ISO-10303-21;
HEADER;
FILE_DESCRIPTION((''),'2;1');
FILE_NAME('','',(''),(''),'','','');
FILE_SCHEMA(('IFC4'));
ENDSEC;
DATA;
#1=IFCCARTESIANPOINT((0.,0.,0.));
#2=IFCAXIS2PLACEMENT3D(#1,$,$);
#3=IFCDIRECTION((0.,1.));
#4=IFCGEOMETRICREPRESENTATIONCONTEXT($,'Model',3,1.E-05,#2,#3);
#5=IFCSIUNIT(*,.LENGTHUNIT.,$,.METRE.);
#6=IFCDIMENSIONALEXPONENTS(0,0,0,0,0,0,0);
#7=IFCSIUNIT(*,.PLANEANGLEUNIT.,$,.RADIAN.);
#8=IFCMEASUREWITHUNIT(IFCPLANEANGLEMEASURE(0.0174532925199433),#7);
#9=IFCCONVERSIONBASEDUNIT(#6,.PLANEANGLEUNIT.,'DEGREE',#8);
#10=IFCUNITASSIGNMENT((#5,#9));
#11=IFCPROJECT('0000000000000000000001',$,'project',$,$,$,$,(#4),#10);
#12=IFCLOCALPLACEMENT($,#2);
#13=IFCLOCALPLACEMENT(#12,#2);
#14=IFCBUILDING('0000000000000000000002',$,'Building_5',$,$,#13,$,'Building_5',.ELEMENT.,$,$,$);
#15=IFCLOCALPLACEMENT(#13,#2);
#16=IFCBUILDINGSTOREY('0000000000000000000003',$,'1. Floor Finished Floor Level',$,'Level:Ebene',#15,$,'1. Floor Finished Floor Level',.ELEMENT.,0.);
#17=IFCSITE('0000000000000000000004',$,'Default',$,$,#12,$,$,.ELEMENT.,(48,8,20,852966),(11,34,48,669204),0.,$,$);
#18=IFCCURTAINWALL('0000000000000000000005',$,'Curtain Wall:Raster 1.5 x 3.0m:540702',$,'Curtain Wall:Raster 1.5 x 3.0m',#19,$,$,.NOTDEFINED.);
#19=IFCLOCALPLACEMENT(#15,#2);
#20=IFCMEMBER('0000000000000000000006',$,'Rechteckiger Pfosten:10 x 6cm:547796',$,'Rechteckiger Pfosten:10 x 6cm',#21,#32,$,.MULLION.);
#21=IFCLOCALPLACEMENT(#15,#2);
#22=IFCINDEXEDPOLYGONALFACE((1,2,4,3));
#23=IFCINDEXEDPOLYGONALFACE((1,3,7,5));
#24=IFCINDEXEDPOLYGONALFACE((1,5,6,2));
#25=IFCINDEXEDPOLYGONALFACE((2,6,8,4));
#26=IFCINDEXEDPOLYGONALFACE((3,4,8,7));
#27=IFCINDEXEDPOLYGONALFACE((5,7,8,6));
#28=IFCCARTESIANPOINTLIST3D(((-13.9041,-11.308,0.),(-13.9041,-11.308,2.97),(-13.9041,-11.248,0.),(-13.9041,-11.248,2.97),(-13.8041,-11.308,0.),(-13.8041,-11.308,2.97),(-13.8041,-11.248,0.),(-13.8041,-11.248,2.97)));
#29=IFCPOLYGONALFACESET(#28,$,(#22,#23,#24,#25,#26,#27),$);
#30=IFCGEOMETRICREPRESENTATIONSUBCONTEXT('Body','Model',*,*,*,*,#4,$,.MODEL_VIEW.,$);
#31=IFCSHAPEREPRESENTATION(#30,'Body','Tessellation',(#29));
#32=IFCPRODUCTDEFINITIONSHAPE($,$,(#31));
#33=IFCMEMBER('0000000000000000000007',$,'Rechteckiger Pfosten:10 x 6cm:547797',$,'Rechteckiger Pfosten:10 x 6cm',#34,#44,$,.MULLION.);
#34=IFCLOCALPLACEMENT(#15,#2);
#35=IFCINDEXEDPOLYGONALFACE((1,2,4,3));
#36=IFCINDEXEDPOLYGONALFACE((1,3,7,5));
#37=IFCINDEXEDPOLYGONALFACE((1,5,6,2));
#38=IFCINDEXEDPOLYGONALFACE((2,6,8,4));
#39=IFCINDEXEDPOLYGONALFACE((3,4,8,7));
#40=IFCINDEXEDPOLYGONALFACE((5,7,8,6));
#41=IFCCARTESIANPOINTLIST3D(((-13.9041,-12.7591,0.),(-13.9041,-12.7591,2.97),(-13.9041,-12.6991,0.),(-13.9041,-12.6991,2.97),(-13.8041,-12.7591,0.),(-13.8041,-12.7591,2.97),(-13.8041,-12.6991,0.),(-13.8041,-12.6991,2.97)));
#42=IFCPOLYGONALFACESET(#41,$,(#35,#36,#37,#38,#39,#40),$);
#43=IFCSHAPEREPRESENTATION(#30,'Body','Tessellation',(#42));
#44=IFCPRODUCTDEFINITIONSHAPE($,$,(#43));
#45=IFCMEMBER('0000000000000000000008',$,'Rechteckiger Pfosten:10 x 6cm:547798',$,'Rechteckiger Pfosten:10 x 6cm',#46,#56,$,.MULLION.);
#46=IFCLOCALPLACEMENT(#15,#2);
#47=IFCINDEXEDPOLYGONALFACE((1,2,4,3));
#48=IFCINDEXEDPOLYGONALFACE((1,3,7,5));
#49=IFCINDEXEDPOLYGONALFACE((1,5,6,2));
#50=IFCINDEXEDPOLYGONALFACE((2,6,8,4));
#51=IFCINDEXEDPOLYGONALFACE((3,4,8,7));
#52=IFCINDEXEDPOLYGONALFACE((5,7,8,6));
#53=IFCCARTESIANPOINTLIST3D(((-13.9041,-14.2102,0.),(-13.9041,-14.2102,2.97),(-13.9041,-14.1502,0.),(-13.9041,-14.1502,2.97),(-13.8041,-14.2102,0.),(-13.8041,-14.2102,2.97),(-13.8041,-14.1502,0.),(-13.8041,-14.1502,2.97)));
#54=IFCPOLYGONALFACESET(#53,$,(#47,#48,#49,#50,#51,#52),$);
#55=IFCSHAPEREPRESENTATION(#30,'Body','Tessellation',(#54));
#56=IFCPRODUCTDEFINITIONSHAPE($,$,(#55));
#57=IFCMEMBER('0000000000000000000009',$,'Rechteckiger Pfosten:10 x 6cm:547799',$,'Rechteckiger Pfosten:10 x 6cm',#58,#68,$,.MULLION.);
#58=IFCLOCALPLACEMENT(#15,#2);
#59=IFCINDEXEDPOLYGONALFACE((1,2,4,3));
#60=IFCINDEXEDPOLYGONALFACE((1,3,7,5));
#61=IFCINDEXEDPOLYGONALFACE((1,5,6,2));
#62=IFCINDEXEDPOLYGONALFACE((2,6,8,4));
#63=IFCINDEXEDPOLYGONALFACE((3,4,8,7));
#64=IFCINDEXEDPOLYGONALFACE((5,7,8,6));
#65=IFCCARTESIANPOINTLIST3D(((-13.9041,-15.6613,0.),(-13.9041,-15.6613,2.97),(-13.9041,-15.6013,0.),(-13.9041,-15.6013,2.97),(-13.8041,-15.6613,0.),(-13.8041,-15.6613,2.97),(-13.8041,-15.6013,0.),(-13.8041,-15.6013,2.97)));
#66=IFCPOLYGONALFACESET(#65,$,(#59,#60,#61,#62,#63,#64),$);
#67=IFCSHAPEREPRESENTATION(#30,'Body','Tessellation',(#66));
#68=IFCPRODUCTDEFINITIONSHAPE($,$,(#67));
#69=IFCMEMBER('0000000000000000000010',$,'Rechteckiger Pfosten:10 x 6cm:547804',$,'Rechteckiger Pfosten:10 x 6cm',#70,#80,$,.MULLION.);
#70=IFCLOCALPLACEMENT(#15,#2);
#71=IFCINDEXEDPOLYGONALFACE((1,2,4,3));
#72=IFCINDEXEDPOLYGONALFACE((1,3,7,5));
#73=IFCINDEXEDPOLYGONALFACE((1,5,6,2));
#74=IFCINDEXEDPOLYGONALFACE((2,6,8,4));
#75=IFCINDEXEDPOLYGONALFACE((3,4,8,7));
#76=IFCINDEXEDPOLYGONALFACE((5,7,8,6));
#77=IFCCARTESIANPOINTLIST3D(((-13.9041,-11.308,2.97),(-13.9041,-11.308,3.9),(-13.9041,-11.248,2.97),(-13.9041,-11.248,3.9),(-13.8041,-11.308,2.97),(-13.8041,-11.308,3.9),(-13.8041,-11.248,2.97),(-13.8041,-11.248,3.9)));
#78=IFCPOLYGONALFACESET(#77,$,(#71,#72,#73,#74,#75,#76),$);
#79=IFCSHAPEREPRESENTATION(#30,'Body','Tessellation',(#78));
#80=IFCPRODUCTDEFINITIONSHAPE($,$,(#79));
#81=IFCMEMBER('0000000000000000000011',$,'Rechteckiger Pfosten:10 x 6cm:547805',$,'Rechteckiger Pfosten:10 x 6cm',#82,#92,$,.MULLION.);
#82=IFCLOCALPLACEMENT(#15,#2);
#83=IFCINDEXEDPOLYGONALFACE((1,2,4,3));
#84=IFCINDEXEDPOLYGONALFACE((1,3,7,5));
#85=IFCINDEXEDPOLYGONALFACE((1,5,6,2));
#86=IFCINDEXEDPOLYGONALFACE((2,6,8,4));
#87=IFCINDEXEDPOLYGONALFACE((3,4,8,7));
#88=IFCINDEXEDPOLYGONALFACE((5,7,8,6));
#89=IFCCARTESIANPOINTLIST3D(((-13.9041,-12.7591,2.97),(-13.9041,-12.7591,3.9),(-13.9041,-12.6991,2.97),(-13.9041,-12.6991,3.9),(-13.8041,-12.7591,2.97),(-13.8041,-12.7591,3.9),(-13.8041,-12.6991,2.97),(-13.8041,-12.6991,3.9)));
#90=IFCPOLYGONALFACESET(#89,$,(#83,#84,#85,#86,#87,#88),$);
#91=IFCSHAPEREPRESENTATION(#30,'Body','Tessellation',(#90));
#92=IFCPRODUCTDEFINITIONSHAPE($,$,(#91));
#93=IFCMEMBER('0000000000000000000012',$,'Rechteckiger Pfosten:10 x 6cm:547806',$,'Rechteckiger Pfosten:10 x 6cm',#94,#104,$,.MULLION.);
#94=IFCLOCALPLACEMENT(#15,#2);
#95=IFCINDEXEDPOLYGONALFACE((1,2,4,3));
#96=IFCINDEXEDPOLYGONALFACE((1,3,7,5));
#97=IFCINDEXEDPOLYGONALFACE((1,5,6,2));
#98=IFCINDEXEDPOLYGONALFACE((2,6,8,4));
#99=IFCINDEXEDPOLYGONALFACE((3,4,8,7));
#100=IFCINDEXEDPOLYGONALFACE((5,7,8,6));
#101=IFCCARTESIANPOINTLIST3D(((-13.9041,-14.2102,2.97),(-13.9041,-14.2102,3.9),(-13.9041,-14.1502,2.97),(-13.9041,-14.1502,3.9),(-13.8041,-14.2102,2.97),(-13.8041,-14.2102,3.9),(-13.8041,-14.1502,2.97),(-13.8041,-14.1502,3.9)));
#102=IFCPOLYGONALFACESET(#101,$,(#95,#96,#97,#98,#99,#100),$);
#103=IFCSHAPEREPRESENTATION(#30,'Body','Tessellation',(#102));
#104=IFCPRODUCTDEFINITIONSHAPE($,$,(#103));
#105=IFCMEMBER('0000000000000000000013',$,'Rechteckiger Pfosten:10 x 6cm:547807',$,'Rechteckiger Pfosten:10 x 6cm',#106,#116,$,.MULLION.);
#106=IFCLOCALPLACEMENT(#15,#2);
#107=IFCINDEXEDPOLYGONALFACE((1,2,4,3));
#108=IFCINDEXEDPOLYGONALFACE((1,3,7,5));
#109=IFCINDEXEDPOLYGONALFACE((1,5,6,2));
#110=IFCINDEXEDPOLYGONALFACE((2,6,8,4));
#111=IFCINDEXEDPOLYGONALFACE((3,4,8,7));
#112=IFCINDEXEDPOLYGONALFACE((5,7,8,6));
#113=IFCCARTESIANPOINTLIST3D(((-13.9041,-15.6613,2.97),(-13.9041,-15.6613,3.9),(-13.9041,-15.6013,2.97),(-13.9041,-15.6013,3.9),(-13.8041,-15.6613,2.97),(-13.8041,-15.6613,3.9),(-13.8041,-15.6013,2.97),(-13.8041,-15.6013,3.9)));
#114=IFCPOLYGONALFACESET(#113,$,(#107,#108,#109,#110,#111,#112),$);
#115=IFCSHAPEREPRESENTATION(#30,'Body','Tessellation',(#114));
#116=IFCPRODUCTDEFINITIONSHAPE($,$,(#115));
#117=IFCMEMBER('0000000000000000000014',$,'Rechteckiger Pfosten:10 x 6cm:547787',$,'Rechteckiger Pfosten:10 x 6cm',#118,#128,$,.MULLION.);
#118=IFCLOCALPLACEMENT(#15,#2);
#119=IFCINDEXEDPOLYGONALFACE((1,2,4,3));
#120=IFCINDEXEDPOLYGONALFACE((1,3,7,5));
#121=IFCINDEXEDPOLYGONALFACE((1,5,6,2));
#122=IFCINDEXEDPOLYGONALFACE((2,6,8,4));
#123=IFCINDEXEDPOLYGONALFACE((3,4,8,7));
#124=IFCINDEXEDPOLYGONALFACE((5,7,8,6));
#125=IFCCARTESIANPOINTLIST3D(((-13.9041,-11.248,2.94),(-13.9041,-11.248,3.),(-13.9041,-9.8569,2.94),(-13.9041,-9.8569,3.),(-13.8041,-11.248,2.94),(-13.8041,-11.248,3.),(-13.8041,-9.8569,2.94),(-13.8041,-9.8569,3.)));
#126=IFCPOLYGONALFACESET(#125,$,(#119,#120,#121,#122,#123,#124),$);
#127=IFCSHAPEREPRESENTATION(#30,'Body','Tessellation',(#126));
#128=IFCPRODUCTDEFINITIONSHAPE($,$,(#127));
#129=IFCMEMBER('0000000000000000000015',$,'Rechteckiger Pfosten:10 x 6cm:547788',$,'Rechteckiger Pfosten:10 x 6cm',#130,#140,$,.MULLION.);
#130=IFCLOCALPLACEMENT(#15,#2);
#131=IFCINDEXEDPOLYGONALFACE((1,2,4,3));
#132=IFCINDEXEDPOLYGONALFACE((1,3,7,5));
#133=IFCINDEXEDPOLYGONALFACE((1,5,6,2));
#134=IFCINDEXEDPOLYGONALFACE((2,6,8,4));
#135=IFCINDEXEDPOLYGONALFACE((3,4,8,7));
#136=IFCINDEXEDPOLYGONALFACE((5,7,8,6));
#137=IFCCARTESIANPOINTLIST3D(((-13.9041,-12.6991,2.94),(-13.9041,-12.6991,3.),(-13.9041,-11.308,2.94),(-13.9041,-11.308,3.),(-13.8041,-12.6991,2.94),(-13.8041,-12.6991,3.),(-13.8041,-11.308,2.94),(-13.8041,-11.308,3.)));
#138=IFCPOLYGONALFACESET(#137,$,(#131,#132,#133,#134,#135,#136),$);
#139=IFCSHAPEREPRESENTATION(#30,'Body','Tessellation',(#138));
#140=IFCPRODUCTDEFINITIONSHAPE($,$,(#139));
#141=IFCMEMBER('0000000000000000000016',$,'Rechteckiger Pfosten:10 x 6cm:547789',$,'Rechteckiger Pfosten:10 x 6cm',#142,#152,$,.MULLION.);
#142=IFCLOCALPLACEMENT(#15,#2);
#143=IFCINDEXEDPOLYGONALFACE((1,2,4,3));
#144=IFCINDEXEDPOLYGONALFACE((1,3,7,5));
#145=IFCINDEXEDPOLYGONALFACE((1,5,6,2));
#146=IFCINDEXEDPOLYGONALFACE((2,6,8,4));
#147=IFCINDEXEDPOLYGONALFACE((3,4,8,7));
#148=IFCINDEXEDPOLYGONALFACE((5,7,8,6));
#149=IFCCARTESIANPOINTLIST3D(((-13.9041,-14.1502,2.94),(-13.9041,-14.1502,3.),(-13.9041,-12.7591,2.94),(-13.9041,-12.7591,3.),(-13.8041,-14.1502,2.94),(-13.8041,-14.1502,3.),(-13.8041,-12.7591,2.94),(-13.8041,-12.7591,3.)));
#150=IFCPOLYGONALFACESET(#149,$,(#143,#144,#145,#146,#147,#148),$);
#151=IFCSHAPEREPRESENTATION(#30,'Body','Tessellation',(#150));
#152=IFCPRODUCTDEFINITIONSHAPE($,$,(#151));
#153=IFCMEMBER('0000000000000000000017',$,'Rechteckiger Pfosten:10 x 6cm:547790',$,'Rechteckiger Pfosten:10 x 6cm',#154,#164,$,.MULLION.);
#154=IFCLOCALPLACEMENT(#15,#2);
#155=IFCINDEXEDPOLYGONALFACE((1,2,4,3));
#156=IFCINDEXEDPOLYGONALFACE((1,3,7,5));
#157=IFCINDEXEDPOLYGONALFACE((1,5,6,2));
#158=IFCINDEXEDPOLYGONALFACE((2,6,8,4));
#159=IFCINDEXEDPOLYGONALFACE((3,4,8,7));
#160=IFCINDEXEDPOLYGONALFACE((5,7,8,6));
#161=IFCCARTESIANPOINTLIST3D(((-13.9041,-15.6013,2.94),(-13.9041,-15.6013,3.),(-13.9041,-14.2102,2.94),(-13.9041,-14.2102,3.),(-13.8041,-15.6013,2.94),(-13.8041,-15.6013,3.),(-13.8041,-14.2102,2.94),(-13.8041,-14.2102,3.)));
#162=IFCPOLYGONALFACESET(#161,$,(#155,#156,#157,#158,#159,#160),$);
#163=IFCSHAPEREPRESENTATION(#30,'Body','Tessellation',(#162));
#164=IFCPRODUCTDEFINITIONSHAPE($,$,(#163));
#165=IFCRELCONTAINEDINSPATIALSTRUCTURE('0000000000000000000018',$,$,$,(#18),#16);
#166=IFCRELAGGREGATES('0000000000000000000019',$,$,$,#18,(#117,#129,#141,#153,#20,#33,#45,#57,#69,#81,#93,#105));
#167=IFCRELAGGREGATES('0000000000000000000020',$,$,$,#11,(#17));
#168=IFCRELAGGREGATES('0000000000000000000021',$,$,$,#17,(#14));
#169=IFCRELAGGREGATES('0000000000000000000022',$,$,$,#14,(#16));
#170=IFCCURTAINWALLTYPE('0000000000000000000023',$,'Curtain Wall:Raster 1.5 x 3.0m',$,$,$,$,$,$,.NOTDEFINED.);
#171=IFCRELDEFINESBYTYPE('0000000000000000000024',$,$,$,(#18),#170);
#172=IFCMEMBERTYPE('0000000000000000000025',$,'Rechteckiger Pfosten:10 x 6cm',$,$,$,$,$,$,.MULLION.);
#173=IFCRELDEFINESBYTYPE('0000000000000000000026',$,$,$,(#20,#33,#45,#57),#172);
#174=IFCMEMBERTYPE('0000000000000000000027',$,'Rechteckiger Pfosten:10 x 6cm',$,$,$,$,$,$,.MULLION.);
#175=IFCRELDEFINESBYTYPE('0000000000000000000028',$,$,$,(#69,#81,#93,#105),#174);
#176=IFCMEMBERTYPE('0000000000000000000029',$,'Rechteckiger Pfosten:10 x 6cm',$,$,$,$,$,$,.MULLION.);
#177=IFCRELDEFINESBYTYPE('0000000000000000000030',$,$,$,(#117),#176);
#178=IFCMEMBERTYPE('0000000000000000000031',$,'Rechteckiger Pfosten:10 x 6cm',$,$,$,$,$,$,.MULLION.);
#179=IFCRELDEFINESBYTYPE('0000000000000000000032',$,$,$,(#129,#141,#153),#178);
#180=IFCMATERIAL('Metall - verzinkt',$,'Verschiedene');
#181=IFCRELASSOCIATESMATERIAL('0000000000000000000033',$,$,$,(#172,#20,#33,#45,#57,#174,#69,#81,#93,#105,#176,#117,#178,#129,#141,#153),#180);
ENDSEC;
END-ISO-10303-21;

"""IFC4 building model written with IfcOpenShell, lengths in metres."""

from ifc_helpers import new_model, entity, si_unit, converted_unit, direction, frame, origin, place, context, subcontext, project, spatial, indexed_curve, outline, extrude, source, transform, mapped, material, type_object, type_shapes, element, aggregate, save


model = new_model("IFC4")

# Units and contexts
model_context = context("Model", 3, precision=1e-05, world=origin(), true_north=direction((0.0, 1.0)))
body_context = subcontext(model_context, "Body", "Model", "MODEL_VIEW")
ifc_project = project(units=[si_unit("LENGTHUNIT", "METRE"), converted_unit("PLANEANGLEUNIT", "DEGREE", entity("IfcPlaneAngleMeasure", 0.0174532925199433), si_unit("PLANEANGLEUNIT", "RADIAN"), dimensions=[0, 0, 0, 0, 0, 0, 0])], contexts=[model_context])

# Site, building, storey
site_placement = place(None, origin())
site = spatial("IfcSite", under=ifc_project, at=site_placement, Name="Default", CompositionType="ELEMENT", RefLatitude=(48, 8, 20, 852966), RefLongitude=(11, 34, 48, 669204), RefElevation=0.0)
building_placement = place(site_placement, origin())
building = spatial("IfcBuilding", under=site, at=building_placement, Name="Building_5", LongName="Building_5", CompositionType="ELEMENT")
storey_placement = place(building_placement, origin())
storey = spatial("IfcBuildingStorey", under=building, at=storey_placement, Name="1. Floor Finished Floor Level", ObjectType="Level:Ebene", LongName="1. Floor Finished Floor Level", CompositionType="ELEMENT", Elevation=0.0)

# Curtain wall, members
curtain_wall_type = type_object("IfcCurtainWallType", Name="Curtain Wall:Raster 1.5 x 3.0m", PredefinedType="NOTDEFINED")
curtain_wall_placement = place(storey_placement, origin())
curtain_wall = element("IfcCurtainWall", 1, at=curtain_wall_placement, inside=storey, type_object=curtain_wall_type, Name="Curtain Wall:Raster 1.5 x 3.0m:540702", ObjectType="Curtain Wall:Raster 1.5 x 3.0m", PredefinedType="NOTDEFINED")
ifc_material_1 = material(Name="Metall - verzinkt", Category="Verschiedene")
member_type_1 = type_object("IfcMemberType", Name="Rechteckiger Pfosten:10 x 6cm", PredefinedType="MULLION", material=ifc_material_1)
shared_shape_1 = source(origin(), body_context, "Body", "SweptSolid", [
    extrude(outline(indexed_curve([(-0.03, -0.05), (0.03, -0.05), (0.03, 0.05), (-0.03, 0.05), (-0.03, -0.05)], self_intersect=False)), frame((0.0, 0.0, -2.97), z_axis=(0.0, 0.0, 1.0), x_axis=(-1.0, 0.0, 0.0)), (0.0, 0.0, 1.0), 2.97),
])
type_shapes(member_type_1, [shared_shape_1])
member_1_placement = place(curtain_wall_placement, frame((-13.8541, -11.278, 0.0), z_axis=(0.0, 0.0, -1.0), x_axis=(0.0, -1.0, 0.0)))
member_1 = element("IfcMember", 2, at=member_1_placement, type_object=member_type_1, material=ifc_material_1, Name="Rechteckiger Pfosten:10 x 6cm:547796", ObjectType="Rechteckiger Pfosten:10 x 6cm", PredefinedType="MULLION", context=body_context, shape_type="MappedRepresentation", body=[
    mapped(shared_shape_1, transform((0.0, 0.0, 0.0), scale=1.0)),
])
member_2_placement = place(curtain_wall_placement, frame((-13.8541, -12.7291, 0.0), z_axis=(0.0, 0.0, -1.0), x_axis=(0.0, -1.0, 0.0)))
member_2 = element("IfcMember", 3, at=member_2_placement, type_object=member_type_1, material=ifc_material_1, Name="Rechteckiger Pfosten:10 x 6cm:547797", ObjectType="Rechteckiger Pfosten:10 x 6cm", PredefinedType="MULLION", context=body_context, shape_type="MappedRepresentation", body=[
    mapped(shared_shape_1, transform((0.0, 0.0, 0.0), scale=1.0)),
])
member_3_placement = place(curtain_wall_placement, frame((-13.8541, -14.1802, 0.0), z_axis=(0.0, 0.0, -1.0), x_axis=(0.0, -1.0, 0.0)))
member_3 = element("IfcMember", 4, at=member_3_placement, type_object=member_type_1, material=ifc_material_1, Name="Rechteckiger Pfosten:10 x 6cm:547798", ObjectType="Rechteckiger Pfosten:10 x 6cm", PredefinedType="MULLION", context=body_context, shape_type="MappedRepresentation", body=[
    mapped(shared_shape_1, transform((0.0, 0.0, 0.0), scale=1.0)),
])
member_4_placement = place(curtain_wall_placement, frame((-13.8541, -15.6313, 0.0), z_axis=(0.0, 0.0, -1.0), x_axis=(0.0, -1.0, 0.0)))
member_4 = element("IfcMember", 5, at=member_4_placement, type_object=member_type_1, material=ifc_material_1, Name="Rechteckiger Pfosten:10 x 6cm:547799", ObjectType="Rechteckiger Pfosten:10 x 6cm", PredefinedType="MULLION", context=body_context, shape_type="MappedRepresentation", body=[
    mapped(shared_shape_1, transform((0.0, 0.0, 0.0), scale=1.0)),
])
member_type_2 = type_object("IfcMemberType", Name="Rechteckiger Pfosten:10 x 6cm", PredefinedType="MULLION", material=ifc_material_1)
shared_shape_2 = source(origin(), body_context, "Body", "SweptSolid", [
    extrude(outline(indexed_curve([(-0.03, -0.05), (0.03, -0.05), (0.03, 0.05), (-0.03, 0.05), (-0.03, -0.05)], self_intersect=False)), frame((0.0, 0.0, -0.93), z_axis=(0.0, 0.0, 1.0), x_axis=(-1.0, 0.0, 0.0)), (0.0, 0.0, 1.0), 0.93),
])
type_shapes(member_type_2, [shared_shape_2])
member_5_placement = place(curtain_wall_placement, frame((-13.8541, -11.278, 2.97), z_axis=(0.0, 0.0, -1.0), x_axis=(0.0, -1.0, 0.0)))
member_5 = element("IfcMember", 6, at=member_5_placement, type_object=member_type_2, material=ifc_material_1, Name="Rechteckiger Pfosten:10 x 6cm:547804", ObjectType="Rechteckiger Pfosten:10 x 6cm", PredefinedType="MULLION", context=body_context, shape_type="MappedRepresentation", body=[
    mapped(shared_shape_2, transform((0.0, 0.0, 0.0), scale=1.0)),
])
member_6_placement = place(curtain_wall_placement, frame((-13.8541, -12.7291, 2.97), z_axis=(0.0, 0.0, -1.0), x_axis=(0.0, -1.0, 0.0)))
member_6 = element("IfcMember", 7, at=member_6_placement, type_object=member_type_2, material=ifc_material_1, Name="Rechteckiger Pfosten:10 x 6cm:547805", ObjectType="Rechteckiger Pfosten:10 x 6cm", PredefinedType="MULLION", context=body_context, shape_type="MappedRepresentation", body=[
    mapped(shared_shape_2, transform((0.0, 0.0, 0.0), scale=1.0)),
])
member_7_placement = place(curtain_wall_placement, frame((-13.8541, -14.1802, 2.97), z_axis=(0.0, 0.0, -1.0), x_axis=(0.0, -1.0, 0.0)))
member_7 = element("IfcMember", 8, at=member_7_placement, type_object=member_type_2, material=ifc_material_1, Name="Rechteckiger Pfosten:10 x 6cm:547806", ObjectType="Rechteckiger Pfosten:10 x 6cm", PredefinedType="MULLION", context=body_context, shape_type="MappedRepresentation", body=[
    mapped(shared_shape_2, transform((0.0, 0.0, 0.0), scale=1.0)),
])
member_8_placement = place(curtain_wall_placement, frame((-13.8541, -15.6313, 2.97), z_axis=(0.0, 0.0, -1.0), x_axis=(0.0, -1.0, 0.0)))
member_8 = element("IfcMember", 9, at=member_8_placement, type_object=member_type_2, material=ifc_material_1, Name="Rechteckiger Pfosten:10 x 6cm:547807", ObjectType="Rechteckiger Pfosten:10 x 6cm", PredefinedType="MULLION", context=body_context, shape_type="MappedRepresentation", body=[
    mapped(shared_shape_2, transform((0.0, 0.0, 0.0), scale=1.0)),
])
member_type_3 = type_object("IfcMemberType", Name="Rechteckiger Pfosten:10 x 6cm", PredefinedType="MULLION", material=ifc_material_1)
shared_shape_3 = source(origin(), body_context, "Body", "SweptSolid", [
    extrude(outline(indexed_curve([(-0.03, -0.05), (0.03, -0.05), (0.03, 0.05), (-0.03, 0.05), (-0.03, -0.05)], self_intersect=False)), frame((0.0, 0.0, -1.3911), z_axis=(0.0, 0.0, 1.0), x_axis=(-1.0, 0.0, 0.0)), (0.0, 0.0, 1.0), 1.3911),
])
type_shapes(member_type_3, [shared_shape_3])
member_9_placement = place(curtain_wall_placement, frame((-13.8541, -11.248, 2.97), z_axis=(0.0, -1.0, 0.0), x_axis=(0.0, 0.0, 1.0)))
member_9 = element("IfcMember", 10, at=member_9_placement, type_object=member_type_3, material=ifc_material_1, Name="Rechteckiger Pfosten:10 x 6cm:547787", ObjectType="Rechteckiger Pfosten:10 x 6cm", PredefinedType="MULLION", context=body_context, shape_type="MappedRepresentation", body=[
    mapped(shared_shape_3, transform((0.0, 0.0, 0.0), scale=1.0)),
])
member_type_4 = type_object("IfcMemberType", Name="Rechteckiger Pfosten:10 x 6cm", PredefinedType="MULLION", material=ifc_material_1)
shared_shape_4 = source(origin(), body_context, "Body", "SweptSolid", [
    extrude(outline(indexed_curve([(-0.03, -0.05), (0.03, -0.05), (0.03, 0.05), (-0.03, 0.05), (-0.03, -0.05)], self_intersect=False)), frame((0.0, 0.0, -1.3911), z_axis=(0.0, 0.0, 1.0), x_axis=(-1.0, 0.0, 0.0)), (0.0, 0.0, 1.0), 1.3911),
])
type_shapes(member_type_4, [shared_shape_4])
member_10_placement = place(curtain_wall_placement, frame((-13.8541, -12.6991, 2.97), z_axis=(0.0, -1.0, 0.0), x_axis=(0.0, 0.0, 1.0)))
member_10 = element("IfcMember", 11, at=member_10_placement, type_object=member_type_4, material=ifc_material_1, Name="Rechteckiger Pfosten:10 x 6cm:547788", ObjectType="Rechteckiger Pfosten:10 x 6cm", PredefinedType="MULLION", context=body_context, shape_type="MappedRepresentation", body=[
    mapped(shared_shape_4, transform((0.0, 0.0, 0.0), scale=1.0)),
])
member_11_placement = place(curtain_wall_placement, frame((-13.8541, -14.1502, 2.97), z_axis=(0.0, -1.0, 0.0), x_axis=(0.0, 0.0, 1.0)))
member_11 = element("IfcMember", 12, at=member_11_placement, type_object=member_type_4, material=ifc_material_1, Name="Rechteckiger Pfosten:10 x 6cm:547789", ObjectType="Rechteckiger Pfosten:10 x 6cm", PredefinedType="MULLION", context=body_context, shape_type="MappedRepresentation", body=[
    mapped(shared_shape_4, transform((0.0, 0.0, 0.0), scale=1.0)),
])
member_12_placement = place(curtain_wall_placement, frame((-13.8541, -15.6013, 2.97), z_axis=(0.0, -1.0, 0.0), x_axis=(0.0, 0.0, 1.0)))
member_12 = element("IfcMember", 13, at=member_12_placement, type_object=member_type_4, material=ifc_material_1, Name="Rechteckiger Pfosten:10 x 6cm:547790", ObjectType="Rechteckiger Pfosten:10 x 6cm", PredefinedType="MULLION", context=body_context, shape_type="MappedRepresentation", body=[
    mapped(shared_shape_4, transform((0.0, 0.0, 0.0), scale=1.0)),
])
aggregate(curtain_wall, [member_9, member_10, member_11, member_12, member_1, member_2, member_3, member_4, member_5, member_6, member_7, member_8])

save(model, "model.ifc")
